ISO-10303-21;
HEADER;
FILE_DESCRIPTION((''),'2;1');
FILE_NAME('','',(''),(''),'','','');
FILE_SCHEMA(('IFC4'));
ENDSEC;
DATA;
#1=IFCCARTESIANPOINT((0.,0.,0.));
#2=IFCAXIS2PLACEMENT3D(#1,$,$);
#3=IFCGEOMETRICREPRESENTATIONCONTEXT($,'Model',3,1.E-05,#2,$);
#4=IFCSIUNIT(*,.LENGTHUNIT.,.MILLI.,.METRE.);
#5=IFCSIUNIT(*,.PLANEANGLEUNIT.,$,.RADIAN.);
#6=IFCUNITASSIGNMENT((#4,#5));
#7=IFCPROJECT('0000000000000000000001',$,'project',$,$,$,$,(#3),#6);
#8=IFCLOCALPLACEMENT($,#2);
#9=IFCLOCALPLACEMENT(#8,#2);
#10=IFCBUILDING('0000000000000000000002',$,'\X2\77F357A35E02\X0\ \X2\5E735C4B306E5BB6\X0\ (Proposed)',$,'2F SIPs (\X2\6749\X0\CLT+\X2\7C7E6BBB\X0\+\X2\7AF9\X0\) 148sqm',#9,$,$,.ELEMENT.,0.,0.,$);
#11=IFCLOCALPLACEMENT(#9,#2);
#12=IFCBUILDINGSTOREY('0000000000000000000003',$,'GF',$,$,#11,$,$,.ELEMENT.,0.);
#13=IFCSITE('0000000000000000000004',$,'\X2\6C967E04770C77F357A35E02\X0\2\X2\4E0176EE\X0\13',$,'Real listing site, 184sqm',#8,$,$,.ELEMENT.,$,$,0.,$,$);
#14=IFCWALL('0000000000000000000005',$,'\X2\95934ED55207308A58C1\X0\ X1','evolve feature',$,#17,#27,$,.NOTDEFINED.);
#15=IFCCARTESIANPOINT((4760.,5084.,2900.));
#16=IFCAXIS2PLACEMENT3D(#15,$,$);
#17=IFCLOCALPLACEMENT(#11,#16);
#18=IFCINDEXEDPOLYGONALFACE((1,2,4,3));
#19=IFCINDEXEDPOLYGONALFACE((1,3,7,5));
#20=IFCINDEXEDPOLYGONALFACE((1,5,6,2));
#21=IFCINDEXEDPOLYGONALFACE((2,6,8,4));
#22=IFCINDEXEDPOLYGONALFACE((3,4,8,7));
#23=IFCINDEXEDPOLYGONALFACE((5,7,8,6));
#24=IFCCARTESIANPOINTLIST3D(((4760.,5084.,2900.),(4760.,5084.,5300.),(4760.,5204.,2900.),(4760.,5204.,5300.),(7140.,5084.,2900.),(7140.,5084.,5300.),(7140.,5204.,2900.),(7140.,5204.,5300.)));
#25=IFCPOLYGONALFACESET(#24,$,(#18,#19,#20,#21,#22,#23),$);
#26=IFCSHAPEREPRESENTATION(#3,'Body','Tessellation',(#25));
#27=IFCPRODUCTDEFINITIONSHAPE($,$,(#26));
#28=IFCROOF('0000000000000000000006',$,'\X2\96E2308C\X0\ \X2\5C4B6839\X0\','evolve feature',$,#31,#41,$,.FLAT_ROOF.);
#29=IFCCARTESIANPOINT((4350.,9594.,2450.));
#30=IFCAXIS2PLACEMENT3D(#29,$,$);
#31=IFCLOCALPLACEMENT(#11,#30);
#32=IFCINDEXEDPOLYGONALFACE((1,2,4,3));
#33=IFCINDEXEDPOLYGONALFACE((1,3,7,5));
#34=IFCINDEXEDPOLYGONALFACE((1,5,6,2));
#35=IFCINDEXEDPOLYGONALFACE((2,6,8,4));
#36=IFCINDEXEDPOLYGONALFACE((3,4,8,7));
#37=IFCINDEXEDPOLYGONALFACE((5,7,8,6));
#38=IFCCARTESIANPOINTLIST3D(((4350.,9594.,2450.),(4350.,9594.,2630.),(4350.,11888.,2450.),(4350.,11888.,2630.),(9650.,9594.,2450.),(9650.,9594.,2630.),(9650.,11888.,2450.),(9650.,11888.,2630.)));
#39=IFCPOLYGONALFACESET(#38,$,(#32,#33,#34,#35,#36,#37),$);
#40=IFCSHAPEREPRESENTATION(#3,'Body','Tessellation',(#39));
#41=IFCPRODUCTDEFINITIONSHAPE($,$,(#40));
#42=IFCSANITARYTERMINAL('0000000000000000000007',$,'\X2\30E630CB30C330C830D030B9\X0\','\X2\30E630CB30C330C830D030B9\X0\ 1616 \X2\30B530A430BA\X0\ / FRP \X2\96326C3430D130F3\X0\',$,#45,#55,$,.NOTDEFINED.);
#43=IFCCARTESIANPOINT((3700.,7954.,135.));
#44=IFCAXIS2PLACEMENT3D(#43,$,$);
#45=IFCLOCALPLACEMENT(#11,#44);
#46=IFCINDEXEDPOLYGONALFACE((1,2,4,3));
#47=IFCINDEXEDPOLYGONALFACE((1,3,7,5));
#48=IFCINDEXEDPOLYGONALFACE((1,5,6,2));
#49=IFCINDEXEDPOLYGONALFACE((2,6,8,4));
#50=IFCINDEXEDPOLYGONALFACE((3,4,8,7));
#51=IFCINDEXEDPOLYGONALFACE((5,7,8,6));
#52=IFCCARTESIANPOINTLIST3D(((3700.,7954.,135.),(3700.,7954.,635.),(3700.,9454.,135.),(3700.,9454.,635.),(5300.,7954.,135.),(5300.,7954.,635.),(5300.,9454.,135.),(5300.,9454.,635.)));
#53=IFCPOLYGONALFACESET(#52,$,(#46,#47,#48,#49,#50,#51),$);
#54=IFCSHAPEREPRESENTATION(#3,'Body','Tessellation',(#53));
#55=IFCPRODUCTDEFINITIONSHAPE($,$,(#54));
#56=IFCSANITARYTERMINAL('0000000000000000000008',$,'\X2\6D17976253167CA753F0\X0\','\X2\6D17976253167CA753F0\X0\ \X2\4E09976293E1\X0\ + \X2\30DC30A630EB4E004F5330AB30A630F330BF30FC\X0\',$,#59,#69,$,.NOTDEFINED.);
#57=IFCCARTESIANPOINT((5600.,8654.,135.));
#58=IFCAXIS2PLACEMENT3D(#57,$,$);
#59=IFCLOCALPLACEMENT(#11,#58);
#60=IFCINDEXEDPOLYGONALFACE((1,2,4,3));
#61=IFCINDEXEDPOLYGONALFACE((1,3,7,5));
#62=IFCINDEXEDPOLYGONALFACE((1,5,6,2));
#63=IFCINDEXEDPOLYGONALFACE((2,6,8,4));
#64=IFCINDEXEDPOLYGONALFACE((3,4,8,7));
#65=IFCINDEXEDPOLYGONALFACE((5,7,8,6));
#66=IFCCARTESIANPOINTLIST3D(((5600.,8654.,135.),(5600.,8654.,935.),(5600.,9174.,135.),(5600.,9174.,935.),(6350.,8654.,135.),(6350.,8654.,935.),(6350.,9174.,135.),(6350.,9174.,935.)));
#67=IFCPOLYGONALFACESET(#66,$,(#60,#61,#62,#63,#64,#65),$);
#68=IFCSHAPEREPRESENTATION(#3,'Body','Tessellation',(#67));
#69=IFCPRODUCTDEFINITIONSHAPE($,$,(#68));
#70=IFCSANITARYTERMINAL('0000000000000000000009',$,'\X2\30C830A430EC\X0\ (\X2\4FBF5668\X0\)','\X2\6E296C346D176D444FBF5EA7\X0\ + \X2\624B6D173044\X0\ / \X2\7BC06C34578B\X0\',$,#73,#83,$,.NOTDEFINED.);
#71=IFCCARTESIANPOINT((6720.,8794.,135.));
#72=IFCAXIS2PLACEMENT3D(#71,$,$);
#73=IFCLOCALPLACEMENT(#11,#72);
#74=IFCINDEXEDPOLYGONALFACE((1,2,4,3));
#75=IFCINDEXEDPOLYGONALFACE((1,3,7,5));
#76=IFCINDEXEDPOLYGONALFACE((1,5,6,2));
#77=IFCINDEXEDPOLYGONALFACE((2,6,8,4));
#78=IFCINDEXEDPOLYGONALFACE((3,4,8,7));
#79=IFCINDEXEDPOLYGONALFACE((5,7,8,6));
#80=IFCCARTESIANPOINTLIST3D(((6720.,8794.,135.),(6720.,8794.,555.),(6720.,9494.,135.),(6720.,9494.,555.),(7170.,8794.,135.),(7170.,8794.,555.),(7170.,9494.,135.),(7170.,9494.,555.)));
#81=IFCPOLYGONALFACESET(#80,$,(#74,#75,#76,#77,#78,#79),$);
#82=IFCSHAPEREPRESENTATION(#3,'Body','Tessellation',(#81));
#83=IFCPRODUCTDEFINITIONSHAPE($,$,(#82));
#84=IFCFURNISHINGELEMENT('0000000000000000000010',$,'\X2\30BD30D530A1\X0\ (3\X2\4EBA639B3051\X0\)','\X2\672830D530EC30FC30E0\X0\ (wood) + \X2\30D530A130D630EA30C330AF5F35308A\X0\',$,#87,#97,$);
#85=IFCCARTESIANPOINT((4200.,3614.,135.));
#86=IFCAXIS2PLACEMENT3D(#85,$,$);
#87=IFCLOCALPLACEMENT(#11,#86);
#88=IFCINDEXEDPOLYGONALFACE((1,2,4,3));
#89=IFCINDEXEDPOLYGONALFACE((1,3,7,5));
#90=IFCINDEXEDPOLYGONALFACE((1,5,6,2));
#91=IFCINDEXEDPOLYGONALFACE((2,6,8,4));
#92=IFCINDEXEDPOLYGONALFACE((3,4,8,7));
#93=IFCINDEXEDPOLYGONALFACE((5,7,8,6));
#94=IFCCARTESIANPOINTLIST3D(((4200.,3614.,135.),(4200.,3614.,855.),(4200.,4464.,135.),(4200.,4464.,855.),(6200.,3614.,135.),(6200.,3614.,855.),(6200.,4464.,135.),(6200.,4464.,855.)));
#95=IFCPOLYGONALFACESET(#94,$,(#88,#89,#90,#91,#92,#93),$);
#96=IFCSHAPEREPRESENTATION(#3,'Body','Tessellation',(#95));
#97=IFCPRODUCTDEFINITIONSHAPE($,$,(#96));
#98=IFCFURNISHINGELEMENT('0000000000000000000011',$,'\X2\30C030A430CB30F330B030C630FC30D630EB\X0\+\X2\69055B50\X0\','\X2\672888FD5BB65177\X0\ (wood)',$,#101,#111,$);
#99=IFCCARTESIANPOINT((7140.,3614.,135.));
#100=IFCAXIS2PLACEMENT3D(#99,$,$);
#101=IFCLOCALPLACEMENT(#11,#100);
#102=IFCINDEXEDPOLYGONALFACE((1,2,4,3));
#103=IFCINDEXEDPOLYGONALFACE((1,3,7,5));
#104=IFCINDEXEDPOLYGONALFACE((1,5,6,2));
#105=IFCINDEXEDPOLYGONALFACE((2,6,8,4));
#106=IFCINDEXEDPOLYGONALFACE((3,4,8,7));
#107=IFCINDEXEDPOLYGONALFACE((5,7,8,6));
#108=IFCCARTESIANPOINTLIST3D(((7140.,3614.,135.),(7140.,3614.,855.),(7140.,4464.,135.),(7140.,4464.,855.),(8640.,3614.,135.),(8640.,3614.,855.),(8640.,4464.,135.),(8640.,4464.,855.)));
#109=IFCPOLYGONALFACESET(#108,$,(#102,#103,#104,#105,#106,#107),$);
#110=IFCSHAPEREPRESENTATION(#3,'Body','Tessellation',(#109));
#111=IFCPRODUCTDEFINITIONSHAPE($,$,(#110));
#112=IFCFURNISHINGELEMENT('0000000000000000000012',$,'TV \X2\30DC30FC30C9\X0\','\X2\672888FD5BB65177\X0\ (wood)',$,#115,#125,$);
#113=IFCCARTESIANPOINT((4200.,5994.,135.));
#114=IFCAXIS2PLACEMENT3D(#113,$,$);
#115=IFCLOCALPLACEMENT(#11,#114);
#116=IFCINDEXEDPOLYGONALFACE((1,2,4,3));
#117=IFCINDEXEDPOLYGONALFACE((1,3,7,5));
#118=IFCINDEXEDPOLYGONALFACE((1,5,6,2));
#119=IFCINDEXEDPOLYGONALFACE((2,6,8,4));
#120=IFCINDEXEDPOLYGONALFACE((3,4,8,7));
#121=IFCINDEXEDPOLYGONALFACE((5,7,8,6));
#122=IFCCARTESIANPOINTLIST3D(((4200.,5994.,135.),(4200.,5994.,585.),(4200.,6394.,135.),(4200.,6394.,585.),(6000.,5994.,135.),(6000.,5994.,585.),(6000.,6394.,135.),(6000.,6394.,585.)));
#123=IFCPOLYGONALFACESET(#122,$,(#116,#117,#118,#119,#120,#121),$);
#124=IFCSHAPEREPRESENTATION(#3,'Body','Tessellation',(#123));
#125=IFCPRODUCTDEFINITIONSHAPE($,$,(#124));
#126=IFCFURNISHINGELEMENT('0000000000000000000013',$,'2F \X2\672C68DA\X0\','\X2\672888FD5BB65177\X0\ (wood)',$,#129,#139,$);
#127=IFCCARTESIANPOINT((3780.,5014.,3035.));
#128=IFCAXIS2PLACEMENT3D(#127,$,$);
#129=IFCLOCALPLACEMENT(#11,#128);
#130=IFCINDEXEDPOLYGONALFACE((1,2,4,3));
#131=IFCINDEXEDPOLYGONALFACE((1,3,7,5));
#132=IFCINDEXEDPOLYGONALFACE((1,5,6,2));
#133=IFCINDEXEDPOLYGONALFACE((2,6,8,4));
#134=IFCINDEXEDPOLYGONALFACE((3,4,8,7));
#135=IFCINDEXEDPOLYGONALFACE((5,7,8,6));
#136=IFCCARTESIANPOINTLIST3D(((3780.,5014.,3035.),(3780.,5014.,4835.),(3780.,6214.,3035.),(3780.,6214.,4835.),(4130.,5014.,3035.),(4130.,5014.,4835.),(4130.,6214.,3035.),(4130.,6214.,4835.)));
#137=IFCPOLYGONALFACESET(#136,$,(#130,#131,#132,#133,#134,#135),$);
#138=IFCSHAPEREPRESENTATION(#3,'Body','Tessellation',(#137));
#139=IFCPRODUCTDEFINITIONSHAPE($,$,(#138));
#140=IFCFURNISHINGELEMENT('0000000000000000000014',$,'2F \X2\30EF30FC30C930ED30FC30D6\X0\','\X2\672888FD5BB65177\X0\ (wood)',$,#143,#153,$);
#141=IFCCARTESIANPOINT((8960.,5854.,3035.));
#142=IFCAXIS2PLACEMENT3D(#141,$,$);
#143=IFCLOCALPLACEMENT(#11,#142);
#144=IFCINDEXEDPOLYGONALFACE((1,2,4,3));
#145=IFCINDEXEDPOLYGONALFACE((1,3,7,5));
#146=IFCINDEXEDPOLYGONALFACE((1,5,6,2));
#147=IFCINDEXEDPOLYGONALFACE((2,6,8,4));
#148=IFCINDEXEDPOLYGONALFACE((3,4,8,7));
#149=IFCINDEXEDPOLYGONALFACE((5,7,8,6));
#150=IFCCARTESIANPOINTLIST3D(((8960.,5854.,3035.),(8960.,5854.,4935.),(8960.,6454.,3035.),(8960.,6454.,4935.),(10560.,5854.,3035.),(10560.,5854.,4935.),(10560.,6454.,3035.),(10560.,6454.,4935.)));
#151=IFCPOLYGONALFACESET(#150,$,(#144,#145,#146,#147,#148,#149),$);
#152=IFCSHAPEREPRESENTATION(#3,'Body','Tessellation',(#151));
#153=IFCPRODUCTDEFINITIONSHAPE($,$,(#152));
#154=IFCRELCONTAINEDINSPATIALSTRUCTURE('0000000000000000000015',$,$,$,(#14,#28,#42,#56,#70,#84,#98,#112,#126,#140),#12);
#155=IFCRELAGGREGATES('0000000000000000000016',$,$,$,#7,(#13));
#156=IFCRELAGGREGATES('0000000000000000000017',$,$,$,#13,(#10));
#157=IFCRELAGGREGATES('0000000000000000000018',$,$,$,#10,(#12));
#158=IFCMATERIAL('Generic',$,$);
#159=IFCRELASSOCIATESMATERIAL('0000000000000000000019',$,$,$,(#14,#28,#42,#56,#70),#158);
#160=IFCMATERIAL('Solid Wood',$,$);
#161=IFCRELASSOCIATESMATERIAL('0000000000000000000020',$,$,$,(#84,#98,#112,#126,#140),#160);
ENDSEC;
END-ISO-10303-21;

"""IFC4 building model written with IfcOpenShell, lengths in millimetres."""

from ifc_helpers import new_model, si_unit, frame, frame_2d, origin, place, context, project, spatial, rectangle, extrude, material, element, save


model = new_model("IFC4")

# Units and contexts
model_context = context("Model", 3, precision=1e-05, world=origin())
ifc_project = project(units=[si_unit("LENGTHUNIT", "METRE", prefix="MILLI"), si_unit("PLANEANGLEUNIT", "RADIAN")], contexts=[model_context])

# Site, building, storey
site_placement = place(None, origin())
site = spatial("IfcSite", under=ifc_project, at=site_placement, Name="沖縄県石垣市2丁目13", ObjectType="Real listing site, 184sqm", CompositionType="ELEMENT", RefElevation=0.0)
building_placement = place(site_placement, origin())
building = spatial("IfcBuilding", under=site, at=building_placement, Name="石垣市 平屋の家 (Proposed)", ObjectType="2F SIPs (杉CLT+籾殻+竹) 148sqm", CompositionType="ELEMENT", ElevationOfRefHeight=0.0, ElevationOfTerrain=0.0)
storey_placement = place(building_placement, origin())
storey = spatial("IfcBuildingStorey", under=building, at=storey_placement, Name="GF", CompositionType="ELEMENT", Elevation=0.0)

# Shared definitions
ifc_material_1 = material(Name="Generic")

# Shared definitions
ifc_material_2 = material(Name="Solid Wood")

# Wall
wall_1_placement = place(storey_placement, frame((4760.0, 5084.0, 2900.0)))
element("IfcWall", 1, at=wall_1_placement, inside=storey, material=ifc_material_1, Name="間仕切り壁 X1", Description="evolve feature", PredefinedType="NOTDEFINED", context=model_context, shape_type="SweptSolid", body=[
    extrude(rectangle(XDim=2380.0, YDim=120.0, at=frame_2d((1190.0, 60.0))), frame((4760.0, 5084.0, 2900.0)), (0.0, 0.0, 1.0), 2400.0),
])

# Roof
roof_placement = place(storey_placement, frame((4350.0, 9594.0, 2450.0)))
element("IfcRoof", 2, at=roof_placement, inside=storey, material=ifc_material_1, Name="離れ 屋根", Description="evolve feature", PredefinedType="FLAT_ROOF", context=model_context, shape_type="SweptSolid", body=[
    extrude(rectangle(XDim=5300.0, YDim=2294.0, at=frame_2d((2650.0, 1147.0))), frame((4350.0, 9594.0, 2450.0)), (0.0, 0.0, 1.0), 180.0),
])

# Sanitary terminals
sanitary_terminal_1_placement = place(storey_placement, frame((3700.0, 7954.0, 135.0)))
element("IfcSanitaryTerminal", 3, at=sanitary_terminal_1_placement, inside=storey, material=ifc_material_1, Name="ユニットバス", Description="ユニットバス 1616 サイズ / FRP 防水パン", PredefinedType="NOTDEFINED", context=model_context, shape_type="SweptSolid", body=[
    extrude(rectangle(XDim=1600.0, YDim=1500.0, at=frame_2d((800.0, 750.0))), frame((3700.0, 7954.0, 135.0)), (0.0, 0.0, 1.0), 500.0),
])
sanitary_terminal_2_placement = place(storey_placement, frame((5600.0, 8654.0, 135.0)))
element("IfcSanitaryTerminal", 4, at=sanitary_terminal_2_placement, inside=storey, material=ifc_material_1, Name="洗面化粧台", Description="洗面化粧台 三面鏡 + ボウル一体カウンター", PredefinedType="NOTDEFINED", context=model_context, shape_type="SweptSolid", body=[
    extrude(rectangle(XDim=750.0, YDim=520.0, at=frame_2d((375.0, 260.0))), frame((5600.0, 8654.0, 135.0)), (0.0, 0.0, 1.0), 800.0),
])
sanitary_terminal_3_placement = place(storey_placement, frame((6720.0, 8794.0, 135.0)))
element("IfcSanitaryTerminal", 5, at=sanitary_terminal_3_placement, inside=storey, material=ifc_material_1, Name="トイレ (便器)", Description="温水洗浄便座 + 手洗い / 節水型", PredefinedType="NOTDEFINED", context=model_context, shape_type="SweptSolid", body=[
    extrude(rectangle(XDim=450.0, YDim=700.0, at=frame_2d((225.0, 350.0))), frame((6720.0, 8794.0, 135.0)), (0.0, 0.0, 1.0), 420.0),
])

# Furnishing elements
furnishing_1_placement = place(storey_placement, frame((4200.0, 3614.0, 135.0)))
element("IfcFurnishingElement", 6, at=furnishing_1_placement, inside=storey, material=ifc_material_2, Name="ソファ (3人掛け)", Description="木フレーム (wood) + ファブリック張り", context=model_context, shape_type="SweptSolid", body=[
    extrude(rectangle(XDim=2000.0, YDim=850.0, at=frame_2d((1000.0, 425.0))), frame((4200.0, 3614.0, 135.0)), (0.0, 0.0, 1.0), 720.0),
])
furnishing_2_placement = place(storey_placement, frame((7140.0, 3614.0, 135.0)))
element("IfcFurnishingElement", 7, at=furnishing_2_placement, inside=storey, material=ifc_material_2, Name="ダイニングテーブル+椅子", Description="木製家具 (wood)", context=model_context, shape_type="SweptSolid", body=[
    extrude(rectangle(XDim=1500.0, YDim=850.0, at=frame_2d((750.0, 425.0))), frame((7140.0, 3614.0, 135.0)), (0.0, 0.0, 1.0), 720.0),
])
furnishing_3_placement = place(storey_placement, frame((4200.0, 5994.0, 135.0)))
element("IfcFurnishingElement", 8, at=furnishing_3_placement, inside=storey, material=ifc_material_2, Name="TV ボード", Description="木製家具 (wood)", context=model_context, shape_type="SweptSolid", body=[
    extrude(rectangle(XDim=1800.0, YDim=400.0, at=frame_2d((900.0, 200.0))), frame((4200.0, 5994.0, 135.0)), (0.0, 0.0, 1.0), 450.0),
])
furnishing_4_placement = place(storey_placement, frame((3780.0, 5014.0, 3035.0)))
element("IfcFurnishingElement", 9, at=furnishing_4_placement, inside=storey, material=ifc_material_2, Name="2F 本棚", Description="木製家具 (wood)", context=model_context, shape_type="SweptSolid", body=[
    extrude(rectangle(XDim=350.0, YDim=1200.0, at=frame_2d((175.0, 600.0))), frame((3780.0, 5014.0, 3035.0)), (0.0, 0.0, 1.0), 1800.0),
])
furnishing_5_placement = place(storey_placement, frame((8960.0, 5854.0, 3035.0)))
element("IfcFurnishingElement", 10, at=furnishing_5_placement, inside=storey, material=ifc_material_2, Name="2F ワードローブ", Description="木製家具 (wood)", context=model_context, shape_type="SweptSolid", body=[
    extrude(rectangle(XDim=1600.0, YDim=600.0, at=frame_2d((800.0, 300.0))), frame((8960.0, 5854.0, 3035.0)), (0.0, 0.0, 1.0), 1900.0),
])

save(model, "model.ifc")
